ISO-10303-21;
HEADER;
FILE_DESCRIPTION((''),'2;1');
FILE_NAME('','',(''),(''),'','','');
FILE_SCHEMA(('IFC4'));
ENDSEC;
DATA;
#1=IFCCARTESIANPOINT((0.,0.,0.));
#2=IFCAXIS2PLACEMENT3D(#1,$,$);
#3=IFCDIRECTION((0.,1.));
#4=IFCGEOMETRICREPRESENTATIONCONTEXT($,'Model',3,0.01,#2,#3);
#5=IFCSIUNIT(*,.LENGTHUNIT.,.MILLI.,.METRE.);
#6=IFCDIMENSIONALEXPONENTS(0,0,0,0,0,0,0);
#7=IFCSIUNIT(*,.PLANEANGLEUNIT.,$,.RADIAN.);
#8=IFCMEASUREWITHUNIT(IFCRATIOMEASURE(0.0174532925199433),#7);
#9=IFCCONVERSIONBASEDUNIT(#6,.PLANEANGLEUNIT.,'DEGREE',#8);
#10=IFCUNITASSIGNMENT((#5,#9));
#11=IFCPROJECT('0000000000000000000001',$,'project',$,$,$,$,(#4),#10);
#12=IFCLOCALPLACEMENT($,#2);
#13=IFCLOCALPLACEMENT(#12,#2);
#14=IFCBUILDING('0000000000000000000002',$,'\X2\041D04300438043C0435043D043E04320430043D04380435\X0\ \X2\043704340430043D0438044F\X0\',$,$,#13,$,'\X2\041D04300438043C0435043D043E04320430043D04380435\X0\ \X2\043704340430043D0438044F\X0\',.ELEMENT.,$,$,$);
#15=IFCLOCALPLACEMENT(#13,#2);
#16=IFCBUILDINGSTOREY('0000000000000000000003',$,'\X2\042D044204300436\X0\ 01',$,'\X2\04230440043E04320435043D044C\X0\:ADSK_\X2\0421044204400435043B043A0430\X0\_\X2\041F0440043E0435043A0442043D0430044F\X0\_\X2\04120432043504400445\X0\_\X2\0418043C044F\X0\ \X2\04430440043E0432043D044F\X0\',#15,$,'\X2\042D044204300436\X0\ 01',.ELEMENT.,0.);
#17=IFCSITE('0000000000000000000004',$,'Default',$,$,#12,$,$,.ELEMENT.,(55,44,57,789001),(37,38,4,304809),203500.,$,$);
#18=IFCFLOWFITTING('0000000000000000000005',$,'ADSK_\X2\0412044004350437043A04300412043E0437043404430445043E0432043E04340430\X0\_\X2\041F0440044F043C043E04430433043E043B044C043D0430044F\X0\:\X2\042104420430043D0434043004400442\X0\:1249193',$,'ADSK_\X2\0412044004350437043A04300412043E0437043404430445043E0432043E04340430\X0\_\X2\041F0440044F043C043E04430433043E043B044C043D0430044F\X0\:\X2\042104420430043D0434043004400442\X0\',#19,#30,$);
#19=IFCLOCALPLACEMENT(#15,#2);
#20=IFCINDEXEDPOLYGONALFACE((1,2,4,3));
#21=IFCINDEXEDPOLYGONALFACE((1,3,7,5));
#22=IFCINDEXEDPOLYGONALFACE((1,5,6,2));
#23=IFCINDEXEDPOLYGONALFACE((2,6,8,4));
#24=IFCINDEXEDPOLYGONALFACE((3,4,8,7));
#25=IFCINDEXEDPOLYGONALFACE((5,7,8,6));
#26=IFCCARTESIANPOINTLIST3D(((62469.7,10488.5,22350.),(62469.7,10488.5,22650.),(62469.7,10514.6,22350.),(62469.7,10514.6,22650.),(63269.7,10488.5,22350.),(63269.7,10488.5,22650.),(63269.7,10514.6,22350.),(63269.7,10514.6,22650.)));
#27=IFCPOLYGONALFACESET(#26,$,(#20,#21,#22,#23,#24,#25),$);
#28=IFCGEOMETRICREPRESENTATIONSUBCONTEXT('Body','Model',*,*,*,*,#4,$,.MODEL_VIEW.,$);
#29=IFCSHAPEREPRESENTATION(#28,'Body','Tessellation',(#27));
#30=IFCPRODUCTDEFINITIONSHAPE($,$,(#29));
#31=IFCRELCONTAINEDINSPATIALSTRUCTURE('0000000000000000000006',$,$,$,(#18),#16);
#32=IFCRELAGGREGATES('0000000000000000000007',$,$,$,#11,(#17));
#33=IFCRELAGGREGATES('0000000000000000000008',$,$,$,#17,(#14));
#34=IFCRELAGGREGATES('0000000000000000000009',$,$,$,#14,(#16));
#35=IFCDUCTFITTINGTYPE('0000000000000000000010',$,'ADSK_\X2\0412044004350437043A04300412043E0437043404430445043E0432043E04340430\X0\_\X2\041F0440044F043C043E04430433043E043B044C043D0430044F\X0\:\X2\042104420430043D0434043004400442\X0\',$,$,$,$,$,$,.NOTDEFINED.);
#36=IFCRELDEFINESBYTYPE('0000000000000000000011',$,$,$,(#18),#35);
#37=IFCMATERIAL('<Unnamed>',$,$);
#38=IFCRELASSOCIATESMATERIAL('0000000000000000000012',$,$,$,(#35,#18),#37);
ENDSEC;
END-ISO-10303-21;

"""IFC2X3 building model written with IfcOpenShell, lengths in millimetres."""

from ifc_helpers import new_model, entity, si_unit, converted_unit, direction, frame, frame_2d, origin, place, context, subcontext, project, spatial, rectangle, extrude, source, transform, mapped, material, type_object, type_shapes, element, save


model = new_model("IFC2X3")

# Units and contexts
model_context = context("Model", 3, precision=0.01, world=origin(), true_north=direction((0.0, 1.0)))
body_context = subcontext(model_context, "Body", "Model", "MODEL_VIEW")
ifc_project = project(units=[si_unit("LENGTHUNIT", "METRE", prefix="MILLI"), converted_unit("PLANEANGLEUNIT", "DEGREE", entity("IfcRatioMeasure", 0.0174532925199433), si_unit("PLANEANGLEUNIT", "RADIAN"), dimensions=[0, 0, 0, 0, 0, 0, 0])], contexts=[model_context])

# Site, building, storey
site_placement = place(None, frame((0.0, 0.0, 0.0)))
site = spatial("IfcSite", under=ifc_project, at=site_placement, Name="Default", CompositionType="ELEMENT", RefLatitude=(55, 44, 57, 789001), RefLongitude=(37, 38, 4, 304809), RefElevation=203500.0)
building_placement = place(site_placement, origin())
building = spatial("IfcBuilding", under=site, at=building_placement, Name="Наименование здания", LongName="Наименование здания", CompositionType="ELEMENT")
storey_placement = place(building_placement, origin())
storey = spatial("IfcBuildingStorey", under=building, at=storey_placement, Name="Этаж 01", ObjectType="Уровень:ADSK_Стрелка_Проектная_Вверх_Имя уровня", LongName="Этаж 01", CompositionType="ELEMENT", Elevation=0.0)

# Shared definitions
ifc_material_1 = material(Name="<Unnamed>")

# Flow fitting
duct_fitting_type_1 = type_object("IfcDuctFittingType", Name="ADSK_ВрезкаВоздуховода_Прямоугольная:Стандарт", PredefinedType="NOTDEFINED", material=ifc_material_1)
shared_shape_1 = source(origin(), body_context, "Body", "SweptSolid", [
    extrude(rectangle(XDim=26.1, YDim=300.0, at=frame_2d((0.0, 0.0), x_axis=(1.0, 0.0))), frame((7.0, 0.0, -400.0)), (0.0, 0.0, 1.0), 800.0),
])
type_shapes(duct_fitting_type_1, [shared_shape_1])
flow_fitting_1_placement = place(storey_placement, frame((62869.7, 10508.5, 22500.0), z_axis=(-1.0, 0.000003, 0.0), x_axis=(-0.000003, -1.0, 0.0)))
element("IfcFlowFitting", 1, at=flow_fitting_1_placement, inside=storey, type_object=duct_fitting_type_1, material=ifc_material_1, Name="ADSK_ВрезкаВоздуховода_Прямоугольная:Стандарт:1249193", ObjectType="ADSK_ВрезкаВоздуховода_Прямоугольная:Стандарт", context=body_context, shape_type="MappedRepresentation", body=[
    mapped(shared_shape_1, transform((0.0, 0.0, 0.0), scale=1.0)),
])

save(model, "model.ifc")
